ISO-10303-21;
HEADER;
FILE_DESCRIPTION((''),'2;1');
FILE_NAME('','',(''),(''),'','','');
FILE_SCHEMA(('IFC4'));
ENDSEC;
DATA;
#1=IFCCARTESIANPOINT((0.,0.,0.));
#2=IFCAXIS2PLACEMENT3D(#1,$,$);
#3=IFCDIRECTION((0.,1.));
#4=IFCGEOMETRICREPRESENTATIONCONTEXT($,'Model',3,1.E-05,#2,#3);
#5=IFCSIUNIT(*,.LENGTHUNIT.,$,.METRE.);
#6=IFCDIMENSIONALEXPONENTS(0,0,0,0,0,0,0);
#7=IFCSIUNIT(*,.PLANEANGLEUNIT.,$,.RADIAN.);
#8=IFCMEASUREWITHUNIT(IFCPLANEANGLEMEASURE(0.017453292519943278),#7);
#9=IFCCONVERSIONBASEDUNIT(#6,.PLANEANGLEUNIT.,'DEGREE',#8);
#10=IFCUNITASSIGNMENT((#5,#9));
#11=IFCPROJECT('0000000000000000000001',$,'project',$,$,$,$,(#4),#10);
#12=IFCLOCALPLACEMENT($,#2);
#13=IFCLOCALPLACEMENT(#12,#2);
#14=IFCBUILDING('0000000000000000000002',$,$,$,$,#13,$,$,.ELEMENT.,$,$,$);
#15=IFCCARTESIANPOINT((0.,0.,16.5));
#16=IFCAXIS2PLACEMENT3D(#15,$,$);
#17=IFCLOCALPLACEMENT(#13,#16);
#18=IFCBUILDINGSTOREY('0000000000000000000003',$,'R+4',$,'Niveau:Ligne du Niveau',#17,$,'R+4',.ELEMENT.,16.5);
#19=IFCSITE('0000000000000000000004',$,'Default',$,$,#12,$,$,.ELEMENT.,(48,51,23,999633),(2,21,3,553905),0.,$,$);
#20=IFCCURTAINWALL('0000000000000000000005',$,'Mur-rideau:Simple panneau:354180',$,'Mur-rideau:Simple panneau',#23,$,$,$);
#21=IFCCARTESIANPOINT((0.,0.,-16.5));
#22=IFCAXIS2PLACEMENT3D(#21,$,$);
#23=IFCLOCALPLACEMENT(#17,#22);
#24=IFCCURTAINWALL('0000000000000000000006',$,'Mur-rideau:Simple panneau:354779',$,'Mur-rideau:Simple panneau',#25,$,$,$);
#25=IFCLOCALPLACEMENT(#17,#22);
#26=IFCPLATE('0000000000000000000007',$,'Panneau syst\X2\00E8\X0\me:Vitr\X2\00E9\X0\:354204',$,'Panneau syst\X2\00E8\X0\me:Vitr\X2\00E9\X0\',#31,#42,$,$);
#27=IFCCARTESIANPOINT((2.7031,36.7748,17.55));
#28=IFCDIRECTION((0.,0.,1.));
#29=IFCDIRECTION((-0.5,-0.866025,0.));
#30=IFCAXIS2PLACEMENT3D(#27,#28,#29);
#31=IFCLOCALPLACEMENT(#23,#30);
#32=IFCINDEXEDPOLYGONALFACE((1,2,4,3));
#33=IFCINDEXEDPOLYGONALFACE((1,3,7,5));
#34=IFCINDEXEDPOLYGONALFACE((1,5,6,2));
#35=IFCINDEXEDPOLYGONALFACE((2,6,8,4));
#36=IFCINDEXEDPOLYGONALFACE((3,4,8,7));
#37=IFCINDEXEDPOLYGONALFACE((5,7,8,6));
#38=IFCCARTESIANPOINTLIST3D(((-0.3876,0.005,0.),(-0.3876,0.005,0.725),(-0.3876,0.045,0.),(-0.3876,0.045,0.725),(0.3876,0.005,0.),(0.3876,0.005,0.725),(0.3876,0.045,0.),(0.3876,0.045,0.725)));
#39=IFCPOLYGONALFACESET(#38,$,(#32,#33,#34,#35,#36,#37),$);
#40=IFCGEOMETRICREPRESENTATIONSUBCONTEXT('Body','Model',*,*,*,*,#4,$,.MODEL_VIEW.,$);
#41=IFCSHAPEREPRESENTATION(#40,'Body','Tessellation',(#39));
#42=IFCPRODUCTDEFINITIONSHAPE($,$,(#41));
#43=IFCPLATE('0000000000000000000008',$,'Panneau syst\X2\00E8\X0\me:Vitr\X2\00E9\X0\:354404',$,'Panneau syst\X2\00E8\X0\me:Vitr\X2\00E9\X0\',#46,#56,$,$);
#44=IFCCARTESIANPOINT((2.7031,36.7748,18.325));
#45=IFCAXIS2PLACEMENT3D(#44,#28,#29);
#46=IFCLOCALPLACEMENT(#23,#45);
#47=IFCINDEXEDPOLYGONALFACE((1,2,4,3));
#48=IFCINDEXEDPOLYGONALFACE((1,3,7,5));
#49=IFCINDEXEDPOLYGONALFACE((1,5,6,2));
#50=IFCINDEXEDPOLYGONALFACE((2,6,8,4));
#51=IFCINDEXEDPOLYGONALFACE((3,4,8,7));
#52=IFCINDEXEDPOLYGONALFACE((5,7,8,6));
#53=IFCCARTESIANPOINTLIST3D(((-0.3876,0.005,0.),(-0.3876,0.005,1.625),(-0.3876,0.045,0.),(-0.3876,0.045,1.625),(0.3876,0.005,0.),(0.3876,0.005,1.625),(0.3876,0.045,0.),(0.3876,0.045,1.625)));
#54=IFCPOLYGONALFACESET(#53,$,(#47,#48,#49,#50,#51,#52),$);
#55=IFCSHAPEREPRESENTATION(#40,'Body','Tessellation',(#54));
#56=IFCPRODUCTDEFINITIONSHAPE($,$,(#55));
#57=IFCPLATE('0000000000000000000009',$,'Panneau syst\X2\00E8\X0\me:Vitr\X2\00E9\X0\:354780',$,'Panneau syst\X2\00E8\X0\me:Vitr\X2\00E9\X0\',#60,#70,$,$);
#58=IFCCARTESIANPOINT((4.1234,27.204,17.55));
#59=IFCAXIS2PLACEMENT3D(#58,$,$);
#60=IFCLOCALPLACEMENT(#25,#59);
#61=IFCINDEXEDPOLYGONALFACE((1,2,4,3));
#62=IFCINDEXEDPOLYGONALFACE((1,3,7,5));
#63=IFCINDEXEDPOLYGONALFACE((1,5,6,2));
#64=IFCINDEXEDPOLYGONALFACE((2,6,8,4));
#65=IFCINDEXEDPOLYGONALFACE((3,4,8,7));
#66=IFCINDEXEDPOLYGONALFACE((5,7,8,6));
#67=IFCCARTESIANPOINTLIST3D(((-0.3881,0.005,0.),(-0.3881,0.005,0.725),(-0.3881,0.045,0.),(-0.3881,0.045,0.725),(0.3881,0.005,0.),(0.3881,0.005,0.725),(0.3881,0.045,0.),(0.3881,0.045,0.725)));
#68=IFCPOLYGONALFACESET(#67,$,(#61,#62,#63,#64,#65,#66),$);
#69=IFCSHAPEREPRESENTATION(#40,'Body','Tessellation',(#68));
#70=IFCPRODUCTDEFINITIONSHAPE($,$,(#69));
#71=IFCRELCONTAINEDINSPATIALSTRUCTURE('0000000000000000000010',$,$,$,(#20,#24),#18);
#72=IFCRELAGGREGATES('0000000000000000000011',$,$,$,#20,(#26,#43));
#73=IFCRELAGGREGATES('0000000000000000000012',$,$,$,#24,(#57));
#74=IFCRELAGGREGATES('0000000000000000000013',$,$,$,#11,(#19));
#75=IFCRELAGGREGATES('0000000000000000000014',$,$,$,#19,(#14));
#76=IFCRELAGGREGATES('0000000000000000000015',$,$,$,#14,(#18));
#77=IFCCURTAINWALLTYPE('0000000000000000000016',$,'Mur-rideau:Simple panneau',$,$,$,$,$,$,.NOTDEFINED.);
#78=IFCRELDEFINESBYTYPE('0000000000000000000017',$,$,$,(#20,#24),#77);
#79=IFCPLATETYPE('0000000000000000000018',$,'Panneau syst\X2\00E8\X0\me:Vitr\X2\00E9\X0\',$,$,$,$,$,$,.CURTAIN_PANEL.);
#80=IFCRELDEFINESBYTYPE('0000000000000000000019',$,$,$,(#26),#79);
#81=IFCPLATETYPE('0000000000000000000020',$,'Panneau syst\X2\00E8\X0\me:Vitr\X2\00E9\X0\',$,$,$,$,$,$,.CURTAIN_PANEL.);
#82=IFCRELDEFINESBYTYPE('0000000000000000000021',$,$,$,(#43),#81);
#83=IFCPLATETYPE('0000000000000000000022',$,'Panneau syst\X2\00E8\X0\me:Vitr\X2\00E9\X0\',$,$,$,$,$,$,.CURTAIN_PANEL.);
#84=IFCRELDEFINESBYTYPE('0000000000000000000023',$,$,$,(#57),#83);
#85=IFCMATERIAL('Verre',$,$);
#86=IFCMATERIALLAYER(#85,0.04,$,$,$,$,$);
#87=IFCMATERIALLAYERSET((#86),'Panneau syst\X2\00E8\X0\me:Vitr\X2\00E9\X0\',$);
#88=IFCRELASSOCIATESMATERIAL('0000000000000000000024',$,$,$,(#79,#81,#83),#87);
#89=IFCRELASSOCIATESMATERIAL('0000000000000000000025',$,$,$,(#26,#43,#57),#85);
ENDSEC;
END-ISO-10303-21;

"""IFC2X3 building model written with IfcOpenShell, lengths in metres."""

from ifc_helpers import new_model, entity, si_unit, converted_unit, direction, frame, frame_2d, origin, place, context, subcontext, project, spatial, rectangle, extrude, source, transform, mapped, material, layer, layer_set, type_object, type_shapes, element, aggregate, save


model = new_model("IFC2X3")

# Units and contexts
model_context = context("Model", 3, precision=1e-05, world=origin(), true_north=direction((0.0, 1.0)))
body_context = subcontext(model_context, "Body", "Model", "MODEL_VIEW")
ifc_project = project(units=[si_unit("LENGTHUNIT", "METRE"), converted_unit("PLANEANGLEUNIT", "DEGREE", entity("IfcPlaneAngleMeasure", 0.017453292519943278), si_unit("PLANEANGLEUNIT", "RADIAN"), dimensions=[0, 0, 0, 0, 0, 0, 0])], contexts=[model_context])

# Site, building, storey
site_placement = place(None, origin())
site = spatial("IfcSite", under=ifc_project, at=site_placement, Name="Default", CompositionType="ELEMENT", RefLatitude=(48, 51, 23, 999633), RefLongitude=(2, 21, 3, 553905), RefElevation=0.0)
building_placement = place(site_placement, origin())
building = spatial("IfcBuilding", under=site, at=building_placement, CompositionType="ELEMENT")
storey_placement = place(building_placement, frame((0.0, 0.0, 16.5)))
storey = spatial("IfcBuildingStorey", under=building, at=storey_placement, Name="R+4", ObjectType="Niveau:Ligne du Niveau", LongName="R+4", CompositionType="ELEMENT", Elevation=16.5)

# Curtain walls
curtain_wall_type = type_object("IfcCurtainWallType", Name="Mur-rideau:Simple panneau", PredefinedType="NOTDEFINED")
curtain_wall_1_placement = place(storey_placement, frame((0.0, 0.0, -16.5)))
curtain_wall_1 = element("IfcCurtainWall", 1, at=curtain_wall_1_placement, inside=storey, type_object=curtain_wall_type, Name="Mur-rideau:Simple panneau:354180", ObjectType="Mur-rideau:Simple panneau")
curtain_wall_2_placement = place(storey_placement, frame((0.0, 0.0, -16.5)))
curtain_wall_2 = element("IfcCurtainWall", 2, at=curtain_wall_2_placement, inside=storey, type_object=curtain_wall_type, Name="Mur-rideau:Simple panneau:354779", ObjectType="Mur-rideau:Simple panneau")

# Plates
ifc_material_1 = material(Name="Verre")
ifc_layer = layer(ifc_material_1, 0.04)
ifc_layer_set = layer_set([ifc_layer], Name="Panneau système:Vitré")
plate_type_1 = type_object("IfcPlateType", Name="Panneau système:Vitré", PredefinedType="CURTAIN_PANEL", material=ifc_layer_set)
shared_shape_1 = source(origin(), body_context, "Body", "SweptSolid", [
    extrude(rectangle(XDim=0.04, YDim=0.7753, at=frame_2d((0.0, 0.0), x_axis=(1.0, 0.0))), frame((0.0, 0.025, 0.0), z_axis=(0.0, 0.0, 1.0), x_axis=(0.0, 1.0, 0.0)), (0.0, 0.0, 1.0), 0.725),
])
type_shapes(plate_type_1, [shared_shape_1])
plate_1_placement = place(curtain_wall_1_placement, frame((2.7031, 36.7748, 17.55), z_axis=(0.0, 0.0, 1.0), x_axis=(-0.5, -0.866025, 0.0)))
plate_1 = element("IfcPlate", 3, at=plate_1_placement, type_object=plate_type_1, material=ifc_material_1, Name="Panneau système:Vitré:354204", ObjectType="Panneau système:Vitré", context=body_context, shape_type="MappedRepresentation", body=[
    mapped(shared_shape_1, transform((0.0, 0.0, 0.0), scale=1.0)),
])
plate_type_2 = type_object("IfcPlateType", Name="Panneau système:Vitré", PredefinedType="CURTAIN_PANEL", material=ifc_layer_set)
shared_shape_2 = source(origin(), body_context, "Body", "SweptSolid", [
    extrude(rectangle(XDim=0.04, YDim=0.7753, at=frame_2d((0.0, 0.0), x_axis=(1.0, 0.0))), frame((0.0, 0.025, 0.0), z_axis=(0.0, 0.0, 1.0), x_axis=(0.0, 1.0, 0.0)), (0.0, 0.0, 1.0), 1.625),
])
type_shapes(plate_type_2, [shared_shape_2])
plate_2_placement = place(curtain_wall_1_placement, frame((2.7031, 36.7748, 18.325), z_axis=(0.0, 0.0, 1.0), x_axis=(-0.5, -0.866025, 0.0)))
plate_2 = element("IfcPlate", 4, at=plate_2_placement, type_object=plate_type_2, material=ifc_material_1, Name="Panneau système:Vitré:354404", ObjectType="Panneau système:Vitré", context=body_context, shape_type="MappedRepresentation", body=[
    mapped(shared_shape_2, transform((0.0, 0.0, 0.0), scale=1.0)),
])
aggregate(curtain_wall_1, [plate_1, plate_2])
plate_type_3 = type_object("IfcPlateType", Name="Panneau système:Vitré", PredefinedType="CURTAIN_PANEL", material=ifc_layer_set)
shared_shape_3 = source(origin(), body_context, "Body", "SweptSolid", [
    extrude(rectangle(XDim=0.04, YDim=0.7761, at=frame_2d((0.0, 0.0), x_axis=(1.0, 0.0))), frame((0.0, 0.025, 0.0), z_axis=(0.0, 0.0, 1.0), x_axis=(0.0, 1.0, 0.0)), (0.0, 0.0, 1.0), 0.725),
])
type_shapes(plate_type_3, [shared_shape_3])
plate_3_placement = place(curtain_wall_2_placement, frame((4.1234, 27.204, 17.55)))
plate_3 = element("IfcPlate", 5, at=plate_3_placement, type_object=plate_type_3, material=ifc_material_1, Name="Panneau système:Vitré:354780", ObjectType="Panneau système:Vitré", context=body_context, shape_type="MappedRepresentation", body=[
    mapped(shared_shape_3, transform((0.0, 0.0, 0.0), scale=1.0)),
])
aggregate(curtain_wall_2, [plate_3])

save(model, "model.ifc")
